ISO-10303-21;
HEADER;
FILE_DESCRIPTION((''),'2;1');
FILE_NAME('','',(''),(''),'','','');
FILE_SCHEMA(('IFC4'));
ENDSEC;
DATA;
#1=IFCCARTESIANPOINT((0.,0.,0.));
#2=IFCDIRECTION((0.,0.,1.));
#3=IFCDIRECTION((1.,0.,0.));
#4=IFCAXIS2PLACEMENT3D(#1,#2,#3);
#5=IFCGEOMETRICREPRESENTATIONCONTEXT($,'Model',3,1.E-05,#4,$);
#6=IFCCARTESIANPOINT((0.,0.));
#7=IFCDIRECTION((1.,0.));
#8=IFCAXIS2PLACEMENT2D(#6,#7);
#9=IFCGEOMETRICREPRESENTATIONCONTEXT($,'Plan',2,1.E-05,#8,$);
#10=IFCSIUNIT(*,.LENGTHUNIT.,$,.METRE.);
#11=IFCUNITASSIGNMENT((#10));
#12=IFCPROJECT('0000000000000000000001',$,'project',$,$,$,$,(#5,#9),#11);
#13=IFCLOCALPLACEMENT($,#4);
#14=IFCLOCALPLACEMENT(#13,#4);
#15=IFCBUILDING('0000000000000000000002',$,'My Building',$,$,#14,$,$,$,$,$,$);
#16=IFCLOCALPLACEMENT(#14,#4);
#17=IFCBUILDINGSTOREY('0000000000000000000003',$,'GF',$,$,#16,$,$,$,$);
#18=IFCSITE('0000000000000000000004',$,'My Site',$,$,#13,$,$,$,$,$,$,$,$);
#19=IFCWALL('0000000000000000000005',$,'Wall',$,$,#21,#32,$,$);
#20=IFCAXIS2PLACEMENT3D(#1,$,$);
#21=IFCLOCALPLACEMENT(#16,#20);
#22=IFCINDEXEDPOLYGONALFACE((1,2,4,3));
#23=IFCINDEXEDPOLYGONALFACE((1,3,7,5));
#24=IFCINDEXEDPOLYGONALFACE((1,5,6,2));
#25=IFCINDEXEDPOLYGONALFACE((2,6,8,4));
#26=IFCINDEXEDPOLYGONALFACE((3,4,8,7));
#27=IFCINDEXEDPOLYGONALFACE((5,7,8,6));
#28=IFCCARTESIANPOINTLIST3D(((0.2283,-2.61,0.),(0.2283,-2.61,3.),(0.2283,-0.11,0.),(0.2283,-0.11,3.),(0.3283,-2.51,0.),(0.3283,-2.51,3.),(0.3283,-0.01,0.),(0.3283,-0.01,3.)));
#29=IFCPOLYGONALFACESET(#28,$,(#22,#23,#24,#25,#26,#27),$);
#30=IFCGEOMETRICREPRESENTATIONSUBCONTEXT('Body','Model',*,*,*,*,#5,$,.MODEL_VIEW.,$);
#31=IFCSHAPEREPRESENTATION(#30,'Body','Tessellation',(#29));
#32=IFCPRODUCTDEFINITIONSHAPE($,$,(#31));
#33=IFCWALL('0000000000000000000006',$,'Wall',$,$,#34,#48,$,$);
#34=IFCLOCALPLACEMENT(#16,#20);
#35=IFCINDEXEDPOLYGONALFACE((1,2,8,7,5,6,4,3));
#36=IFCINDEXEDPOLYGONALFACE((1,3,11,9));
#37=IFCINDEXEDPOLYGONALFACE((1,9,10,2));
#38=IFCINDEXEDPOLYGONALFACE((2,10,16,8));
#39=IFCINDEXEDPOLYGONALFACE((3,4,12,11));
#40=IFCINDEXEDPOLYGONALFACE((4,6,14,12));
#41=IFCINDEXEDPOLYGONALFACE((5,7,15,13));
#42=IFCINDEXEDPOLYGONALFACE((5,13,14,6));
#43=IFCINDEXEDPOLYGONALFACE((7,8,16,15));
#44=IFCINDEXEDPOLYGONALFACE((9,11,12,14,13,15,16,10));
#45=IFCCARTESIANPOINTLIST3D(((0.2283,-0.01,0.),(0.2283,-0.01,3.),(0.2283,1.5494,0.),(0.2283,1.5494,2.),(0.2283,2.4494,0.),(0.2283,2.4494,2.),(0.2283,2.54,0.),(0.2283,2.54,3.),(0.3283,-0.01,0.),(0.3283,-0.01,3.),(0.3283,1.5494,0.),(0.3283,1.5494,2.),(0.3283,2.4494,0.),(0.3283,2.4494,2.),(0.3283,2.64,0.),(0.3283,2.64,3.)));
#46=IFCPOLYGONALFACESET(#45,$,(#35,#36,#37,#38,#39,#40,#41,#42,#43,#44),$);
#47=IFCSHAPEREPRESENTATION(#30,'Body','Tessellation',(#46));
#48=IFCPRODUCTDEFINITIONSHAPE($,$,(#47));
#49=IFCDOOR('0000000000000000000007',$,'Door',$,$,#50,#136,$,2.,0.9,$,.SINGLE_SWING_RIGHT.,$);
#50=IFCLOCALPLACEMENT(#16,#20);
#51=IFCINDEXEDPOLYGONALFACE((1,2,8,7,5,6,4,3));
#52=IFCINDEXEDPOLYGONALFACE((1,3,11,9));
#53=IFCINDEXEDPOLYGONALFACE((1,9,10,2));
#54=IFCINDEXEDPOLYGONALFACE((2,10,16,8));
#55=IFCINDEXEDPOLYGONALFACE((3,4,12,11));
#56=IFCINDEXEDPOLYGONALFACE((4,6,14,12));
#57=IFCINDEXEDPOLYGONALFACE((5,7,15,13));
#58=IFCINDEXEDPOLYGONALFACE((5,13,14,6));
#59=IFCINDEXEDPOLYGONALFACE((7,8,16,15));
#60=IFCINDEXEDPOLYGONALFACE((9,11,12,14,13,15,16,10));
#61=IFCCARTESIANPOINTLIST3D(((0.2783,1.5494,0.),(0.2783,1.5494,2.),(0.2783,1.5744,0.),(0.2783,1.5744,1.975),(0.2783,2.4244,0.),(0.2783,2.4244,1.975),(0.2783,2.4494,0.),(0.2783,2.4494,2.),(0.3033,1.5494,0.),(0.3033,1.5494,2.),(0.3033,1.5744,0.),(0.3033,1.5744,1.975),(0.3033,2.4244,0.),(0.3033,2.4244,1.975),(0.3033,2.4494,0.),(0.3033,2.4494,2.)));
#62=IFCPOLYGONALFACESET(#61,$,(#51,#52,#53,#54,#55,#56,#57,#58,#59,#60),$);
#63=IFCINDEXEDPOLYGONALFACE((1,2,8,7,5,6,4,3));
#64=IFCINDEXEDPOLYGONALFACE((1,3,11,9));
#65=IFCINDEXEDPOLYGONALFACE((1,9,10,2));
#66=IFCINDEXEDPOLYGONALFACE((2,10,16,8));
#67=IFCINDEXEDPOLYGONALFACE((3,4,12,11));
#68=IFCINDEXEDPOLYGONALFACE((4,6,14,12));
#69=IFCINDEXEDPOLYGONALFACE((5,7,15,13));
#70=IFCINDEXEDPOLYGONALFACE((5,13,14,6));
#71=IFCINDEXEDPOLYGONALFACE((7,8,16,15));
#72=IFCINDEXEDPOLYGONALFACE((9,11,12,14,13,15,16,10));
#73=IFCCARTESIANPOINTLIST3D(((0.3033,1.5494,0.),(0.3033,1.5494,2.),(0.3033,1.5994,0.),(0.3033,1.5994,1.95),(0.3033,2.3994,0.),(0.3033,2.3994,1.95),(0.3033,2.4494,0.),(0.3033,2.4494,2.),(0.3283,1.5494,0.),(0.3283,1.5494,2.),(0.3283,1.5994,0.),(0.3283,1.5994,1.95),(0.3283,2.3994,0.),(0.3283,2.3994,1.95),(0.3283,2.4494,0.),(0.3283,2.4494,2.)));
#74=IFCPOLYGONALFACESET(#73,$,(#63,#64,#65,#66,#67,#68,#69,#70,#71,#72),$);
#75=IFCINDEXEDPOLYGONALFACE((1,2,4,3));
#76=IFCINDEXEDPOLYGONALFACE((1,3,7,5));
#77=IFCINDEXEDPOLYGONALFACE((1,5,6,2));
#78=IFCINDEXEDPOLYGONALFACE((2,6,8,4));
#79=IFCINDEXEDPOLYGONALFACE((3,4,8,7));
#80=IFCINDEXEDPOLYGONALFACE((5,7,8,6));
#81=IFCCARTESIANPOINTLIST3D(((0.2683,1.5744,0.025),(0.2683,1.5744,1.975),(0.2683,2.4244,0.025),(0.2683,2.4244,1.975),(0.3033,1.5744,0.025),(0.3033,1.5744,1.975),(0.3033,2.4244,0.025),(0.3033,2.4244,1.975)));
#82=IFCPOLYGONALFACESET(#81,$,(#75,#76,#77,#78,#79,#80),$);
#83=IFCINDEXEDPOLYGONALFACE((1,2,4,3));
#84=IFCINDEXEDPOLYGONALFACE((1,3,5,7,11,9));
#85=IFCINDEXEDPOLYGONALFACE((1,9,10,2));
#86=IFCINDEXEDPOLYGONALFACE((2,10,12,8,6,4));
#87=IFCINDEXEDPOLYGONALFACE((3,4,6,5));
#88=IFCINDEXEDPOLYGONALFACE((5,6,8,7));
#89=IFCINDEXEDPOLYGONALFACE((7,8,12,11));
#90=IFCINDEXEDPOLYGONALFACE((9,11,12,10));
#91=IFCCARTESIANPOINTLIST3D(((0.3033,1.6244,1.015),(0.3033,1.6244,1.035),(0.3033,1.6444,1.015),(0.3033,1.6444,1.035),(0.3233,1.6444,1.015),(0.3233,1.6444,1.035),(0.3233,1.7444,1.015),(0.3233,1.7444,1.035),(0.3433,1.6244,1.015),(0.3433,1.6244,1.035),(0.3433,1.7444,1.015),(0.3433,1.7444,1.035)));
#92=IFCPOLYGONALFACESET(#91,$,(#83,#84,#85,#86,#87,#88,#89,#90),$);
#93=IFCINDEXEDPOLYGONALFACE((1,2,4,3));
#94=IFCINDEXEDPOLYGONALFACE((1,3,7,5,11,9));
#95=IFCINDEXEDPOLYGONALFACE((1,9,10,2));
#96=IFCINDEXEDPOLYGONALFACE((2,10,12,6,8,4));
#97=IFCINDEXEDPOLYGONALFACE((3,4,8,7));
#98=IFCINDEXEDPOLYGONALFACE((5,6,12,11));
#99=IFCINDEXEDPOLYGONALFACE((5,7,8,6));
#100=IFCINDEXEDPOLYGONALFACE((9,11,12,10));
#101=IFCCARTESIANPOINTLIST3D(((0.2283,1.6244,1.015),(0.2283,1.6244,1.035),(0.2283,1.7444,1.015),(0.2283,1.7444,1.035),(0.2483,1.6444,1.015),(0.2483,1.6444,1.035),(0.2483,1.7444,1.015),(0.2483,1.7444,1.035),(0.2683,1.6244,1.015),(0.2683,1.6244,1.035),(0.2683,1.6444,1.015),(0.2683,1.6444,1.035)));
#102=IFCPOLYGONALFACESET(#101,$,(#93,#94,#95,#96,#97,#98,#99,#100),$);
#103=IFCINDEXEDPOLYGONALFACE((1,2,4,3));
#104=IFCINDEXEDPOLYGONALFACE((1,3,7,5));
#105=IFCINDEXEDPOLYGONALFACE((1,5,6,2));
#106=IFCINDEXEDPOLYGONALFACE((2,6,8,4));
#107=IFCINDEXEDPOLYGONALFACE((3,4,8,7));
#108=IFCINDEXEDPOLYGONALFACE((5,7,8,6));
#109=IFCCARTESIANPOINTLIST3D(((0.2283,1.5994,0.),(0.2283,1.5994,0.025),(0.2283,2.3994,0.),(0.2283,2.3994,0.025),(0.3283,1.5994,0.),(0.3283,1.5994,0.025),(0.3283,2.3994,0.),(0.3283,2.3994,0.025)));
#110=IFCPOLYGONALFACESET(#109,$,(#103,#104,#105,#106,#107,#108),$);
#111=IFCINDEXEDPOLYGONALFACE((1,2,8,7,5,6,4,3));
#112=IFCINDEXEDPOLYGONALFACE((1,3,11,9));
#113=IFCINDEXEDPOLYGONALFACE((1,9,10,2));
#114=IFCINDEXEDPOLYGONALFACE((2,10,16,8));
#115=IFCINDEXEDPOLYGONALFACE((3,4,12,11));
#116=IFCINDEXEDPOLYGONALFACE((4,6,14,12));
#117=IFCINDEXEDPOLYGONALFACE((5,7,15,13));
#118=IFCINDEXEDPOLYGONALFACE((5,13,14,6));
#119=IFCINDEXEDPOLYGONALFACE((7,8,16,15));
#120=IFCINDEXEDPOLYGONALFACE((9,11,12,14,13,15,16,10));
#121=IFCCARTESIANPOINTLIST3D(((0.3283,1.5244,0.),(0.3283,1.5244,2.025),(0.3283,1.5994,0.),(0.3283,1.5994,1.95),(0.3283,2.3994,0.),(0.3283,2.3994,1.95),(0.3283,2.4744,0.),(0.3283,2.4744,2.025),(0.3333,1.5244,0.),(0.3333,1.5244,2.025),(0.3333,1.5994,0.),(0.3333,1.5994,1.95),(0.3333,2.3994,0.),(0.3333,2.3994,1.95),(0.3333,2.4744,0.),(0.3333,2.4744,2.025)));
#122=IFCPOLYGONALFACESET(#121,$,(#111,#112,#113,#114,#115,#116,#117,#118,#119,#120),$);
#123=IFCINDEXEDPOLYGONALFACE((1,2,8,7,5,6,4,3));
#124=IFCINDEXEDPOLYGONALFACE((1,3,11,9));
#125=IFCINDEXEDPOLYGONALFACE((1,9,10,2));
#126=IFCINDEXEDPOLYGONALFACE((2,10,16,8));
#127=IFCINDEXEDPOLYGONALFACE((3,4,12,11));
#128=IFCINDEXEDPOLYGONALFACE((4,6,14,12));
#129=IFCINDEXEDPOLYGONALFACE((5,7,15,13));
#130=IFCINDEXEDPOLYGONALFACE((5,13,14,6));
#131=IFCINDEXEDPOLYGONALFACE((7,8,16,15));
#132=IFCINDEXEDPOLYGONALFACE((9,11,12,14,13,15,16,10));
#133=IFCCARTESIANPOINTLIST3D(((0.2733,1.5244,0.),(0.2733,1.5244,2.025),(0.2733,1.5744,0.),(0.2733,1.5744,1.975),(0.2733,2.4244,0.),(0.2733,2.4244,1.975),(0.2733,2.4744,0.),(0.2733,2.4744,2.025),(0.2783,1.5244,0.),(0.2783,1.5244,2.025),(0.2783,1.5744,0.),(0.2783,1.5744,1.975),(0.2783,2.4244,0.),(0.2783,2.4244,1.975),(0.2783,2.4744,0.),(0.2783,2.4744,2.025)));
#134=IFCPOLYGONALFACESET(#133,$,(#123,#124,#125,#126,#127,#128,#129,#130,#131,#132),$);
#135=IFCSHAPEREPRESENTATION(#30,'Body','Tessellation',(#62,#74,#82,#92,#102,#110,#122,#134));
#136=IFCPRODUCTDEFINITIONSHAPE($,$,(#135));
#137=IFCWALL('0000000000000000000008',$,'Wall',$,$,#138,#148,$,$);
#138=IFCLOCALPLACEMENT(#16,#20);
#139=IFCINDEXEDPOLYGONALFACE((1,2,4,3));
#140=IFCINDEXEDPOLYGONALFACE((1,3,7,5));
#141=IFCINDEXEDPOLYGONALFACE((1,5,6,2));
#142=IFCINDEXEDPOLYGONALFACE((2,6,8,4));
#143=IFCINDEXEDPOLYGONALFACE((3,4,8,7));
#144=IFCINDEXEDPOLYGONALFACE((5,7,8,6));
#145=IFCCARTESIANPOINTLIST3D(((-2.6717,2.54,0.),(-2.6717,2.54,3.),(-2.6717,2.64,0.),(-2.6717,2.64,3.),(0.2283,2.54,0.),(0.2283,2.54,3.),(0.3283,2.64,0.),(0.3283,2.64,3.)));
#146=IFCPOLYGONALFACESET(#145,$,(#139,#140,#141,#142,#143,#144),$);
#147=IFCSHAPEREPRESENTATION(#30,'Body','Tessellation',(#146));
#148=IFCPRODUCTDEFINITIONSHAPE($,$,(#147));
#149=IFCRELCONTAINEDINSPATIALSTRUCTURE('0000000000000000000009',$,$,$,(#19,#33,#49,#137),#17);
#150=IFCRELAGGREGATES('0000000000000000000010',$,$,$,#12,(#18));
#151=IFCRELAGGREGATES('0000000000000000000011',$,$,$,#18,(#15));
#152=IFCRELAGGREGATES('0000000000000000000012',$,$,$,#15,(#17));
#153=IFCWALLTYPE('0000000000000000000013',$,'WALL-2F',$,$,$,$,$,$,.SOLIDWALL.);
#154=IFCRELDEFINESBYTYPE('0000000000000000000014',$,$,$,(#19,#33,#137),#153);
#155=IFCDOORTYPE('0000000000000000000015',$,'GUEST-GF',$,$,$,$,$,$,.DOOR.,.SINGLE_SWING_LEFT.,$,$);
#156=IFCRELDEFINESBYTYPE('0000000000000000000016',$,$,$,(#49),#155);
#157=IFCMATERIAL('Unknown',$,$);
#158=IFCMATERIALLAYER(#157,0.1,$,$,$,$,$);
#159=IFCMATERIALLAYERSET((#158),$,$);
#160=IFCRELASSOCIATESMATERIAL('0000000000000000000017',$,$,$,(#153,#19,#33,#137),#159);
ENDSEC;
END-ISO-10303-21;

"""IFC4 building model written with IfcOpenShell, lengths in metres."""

from ifc_helpers import new_model, entity, si_unit, frame, origin_with_axes, origin_2d_with_axis, place, context, subcontext, project, spatial, line, indexed_curve, outline, extrude, shape, source, transform, mapped, material, layer, layer_set, layer_usage, type_object, type_shapes, element, fill, save


model = new_model("IFC4")

# Units and contexts
model_context = context("Model", 3, precision=1e-05, world=origin_with_axes())
plan_context = context("Plan", 2, precision=1e-05, world=origin_2d_with_axis())
body_context_1 = subcontext(model_context, "Body", "Model", "MODEL_VIEW")
body_context_2 = subcontext(plan_context, "Body", "Plan", "PLAN_VIEW")
ifc_project = project(units=[si_unit("LENGTHUNIT", "METRE")], contexts=[model_context, plan_context])

# Site, building, storey
site_placement = place(None, origin_with_axes())
site = spatial("IfcSite", under=ifc_project, at=site_placement, Name="My Site")
building_placement = place(site_placement, origin_with_axes())
building = spatial("IfcBuilding", under=site, at=building_placement, Name="My Building")
storey_placement = place(building_placement, origin_with_axes())
storey = spatial("IfcBuildingStorey", under=building, at=storey_placement, Name="GF")

# Shared definitions
ifc_material = material(Name="Unknown")

# Shared definitions
ifc_layer_1 = layer(ifc_material, 0.1)
ifc_layer_set_1 = layer_set([ifc_layer_1])
wall_type = type_object("IfcWallType", Name="WALL-2F", PredefinedType="SOLIDWALL", material=ifc_layer_set_1)

# Wall
ifc_layer_usage_1 = layer_usage(ifc_layer_set_1, "AXIS2", "POSITIVE", 0.0)
wall_1_placement = place(storey_placement, frame((0.2283, -0.11, 0.0), z_axis=(0.0, 0.0, 1.0), x_axis=(0.0, -1.0, 0.0)))
element("IfcWall", 1, at=wall_1_placement, inside=storey, type_object=wall_type, material=ifc_layer_usage_1, Name="Wall", context=body_context_1, shape_type="SweptSolid", body=[
    extrude(outline(indexed_curve([(0.0, 0.0), (-0.1, 0.1), (2.4, 0.1), (2.5, 0.0)], segments=[line(1, 2, 3, 4, 1)])), origin_with_axes(), (0.0, 0.0, 1.0), 3.0),
])

# Wall, opening, door
ifc_layer_usage_2 = layer_usage(ifc_layer_set_1, "AXIS2", "POSITIVE", 0.0)
wall_2_placement = place(storey_placement, frame((0.3283, -0.01, 0.0), z_axis=(0.0, 0.0, 1.0), x_axis=(0.0, 1.0, 0.0)))
wall_2 = element("IfcWall", 2, at=wall_2_placement, inside=storey, type_object=wall_type, material=ifc_layer_usage_2, Name="Wall", context=body_context_1, shape_type="SweptSolid", body=[
    extrude(outline(indexed_curve([(0.0, 0.0), (0.0, 0.1), (2.55, 0.1), (2.65, 0.0)], segments=[line(1, 2, 3, 4, 1)])), origin_with_axes(), (0.0, 0.0, 1.0), 3.0),
])
shared_shape_1 = source(origin_with_axes(), body_context_1, "Body", "SweptSolid", [
    extrude(outline(indexed_curve([(0.0, 0.0), (0.9, 0.0), (0.9, 2.0), (0.0, 2.0)], segments=[line(1, 2, 3, 4, 1)])), frame((0.0, -0.6, 0.0), z_axis=(0.0, -1.0, 0.0), x_axis=(1.0, 0.0, 0.0)), (0.0, 0.0, -1.0), 1.2),
])
opening_1_placement = place(wall_2_placement, frame((1.5595, 0.0, 0.0), z_axis=(0.0, 0.0, 1.0), x_axis=(1.0, 0.0, 0.0)))
opening_1 = element("IfcOpeningElement", 3, at=opening_1_placement, cuts=wall_2, PredefinedType="OPENING", context=body_context_1, shape_type="MappedRepresentation", body=[
    mapped(shared_shape_1, transform((0.0, 0.0, 0.0), x_axis=(1.0, 0.0, 0.0), y_axis=(0.0, 1.0, 0.0), z_axis=(0.0, 0.0, 1.0), scale=1.0)),
])
door_type_1 = type_object("IfcDoorType", Name="GUEST-GF", OperationType="SINGLE_SWING_LEFT", PredefinedType="DOOR")
shared_shape_2 = source(origin_with_axes(), body_context_1, "Body", "SweptSolid", [
    extrude(outline(indexed_curve([(0.0, 0.0), (0.0, 2.0), (0.9, 2.0), (0.9, 0.0), (0.875, 0.0), (0.875, 1.975), (0.025, 1.975), (0.025, 0.0)], segments=[line(1, 2, 3, 4, 5, 6, 7, 8, 1)])), frame((0.0, 0.025, 0.0), z_axis=(0.0, -1.0, 0.0), x_axis=(1.0, 0.0, 0.0)), (0.0, 0.0, -1.0), 0.025),
    extrude(outline(indexed_curve([(0.0, 0.0), (0.0, 2.0), (0.9, 2.0), (0.9, 0.0), (0.85, 0.0), (0.85, 1.95), (0.05, 1.95), (0.05, 0.0)], segments=[line(1, 2, 3, 4, 5, 6, 7, 8, 1)])), frame((0.0, 0.0, 0.0), z_axis=(0.0, -1.0, 0.0), x_axis=(1.0, 0.0, 0.0)), (0.0, 0.0, -1.0), 0.025),
    extrude(outline(indexed_curve([(0.0, 0.0), (0.85, 0.0), (0.85, 0.035), (0.0, 0.035)], segments=[line(1, 2, 3, 4, 1)])), frame((0.025, 0.025, 0.025), z_axis=(0.0, 0.0, 1.0), x_axis=(1.0, 0.0, 0.0)), (0.0, 0.0, 1.0), 1.95),
    extrude(outline(indexed_curve([(0.0, 0.0), (0.0, -0.04), (0.12, -0.04), (0.12, -0.02), (0.02, -0.02), (0.02, 0.0)], segments=[line(1, 2, 3, 4, 5, 6, 1)])), frame((0.075, 0.025, 1.015), z_axis=(0.0, 0.0, 1.0), x_axis=(1.0, 0.0, 0.0)), (0.0, 0.0, 1.0), 0.02),
    extrude(outline(indexed_curve([(0.0, 0.0), (0.0, 0.04), (0.12, 0.04), (0.12, 0.02), (0.02, 0.02), (0.02, 0.0)], segments=[line(1, 2, 3, 4, 5, 6, 1)])), frame((0.075, 0.06, 1.015), z_axis=(0.0, 0.0, 1.0), x_axis=(1.0, 0.0, 0.0)), (0.0, 0.0, 1.0), 0.02),
    extrude(outline(indexed_curve([(0.0, 0.0), (0.8, 0.0), (0.8, 0.1), (0.0, 0.1)], segments=[line(1, 2, 3, 4, 1)])), frame((0.05, 0.0, 0.0), z_axis=(0.0, 0.0, 1.0), x_axis=(1.0, 0.0, 0.0)), (0.0, 0.0, 1.0), 0.025),
    extrude(outline(indexed_curve([(0.0, 0.0), (0.0, 2.025), (0.95, 2.025), (0.95, 0.0), (0.875, 0.0), (0.875, 1.95), (0.075, 1.95), (0.075, 0.0)], segments=[line(1, 2, 3, 4, 5, 6, 7, 8, 1)])), frame((-0.025, -0.005, 0.0), z_axis=(0.0, -1.0, 0.0), x_axis=(1.0, 0.0, 0.0)), (0.0, 0.0, -1.0), 0.005),
    extrude(outline(indexed_curve([(0.0, 0.0), (0.0, 2.025), (0.95, 2.025), (0.95, 0.0), (0.9, 0.0), (0.9, 1.975), (0.05, 1.975), (0.05, 0.0)], segments=[line(1, 2, 3, 4, 5, 6, 7, 8, 1)])), frame((-0.025, 0.05, 0.0), z_axis=(0.0, -1.0, 0.0), x_axis=(1.0, 0.0, 0.0)), (0.0, 0.0, -1.0), 0.005),
])
shared_shape_3 = source(origin_with_axes(), body_context_2, "Body", "Curve2D", [
    entity("IfcIndexedPolyCurve", entity("IfcCartesianPointList2D", [[0.0, 0.0], [0.0, 0.05], [0.025, 0.05], [0.025, 0.025], [0.05, 0.025], [0.05, 0.0]]), [entity("IfcLineIndex", [1, 2, 3, 4, 5, 6, 1])]),
    entity("IfcIndexedPolyCurve", entity("IfcCartesianPointList2D", [[0.9, 0.0], [0.9, 0.05], [0.875, 0.05], [0.875, 0.025], [0.85, 0.025], [0.85, 0.0]]), [entity("IfcLineIndex", [1, 2, 3, 4, 5, 6, 1])]),
    entity("IfcTrimmedCurve", entity("IfcEllipse", entity("IfcAxis2Placement2D", entity("IfcCartesianPoint", [0.84, 0.05]), entity("IfcDirection", [1.0, 0.0])), 0.815, 0.85), [entity("IfcCartesianPoint", [0.84, 0.9])], [entity("IfcCartesianPoint", [0.025, 0.05])], True, "CARTESIAN"),
    entity("IfcIndexedPolyCurve", entity("IfcCartesianPointList2D", [[0.875, 0.05], [0.84, 0.05], [0.84, 0.9], [0.875, 0.9]]), [entity("IfcLineIndex", [1, 2, 3, 4, 1])]),
])
type_shapes(door_type_1, [shared_shape_2, shared_shape_3])
door_1_placement = place(opening_1_placement, frame((0.0, 0.0, 0.0), z_axis=(0.0, 0.0, 1.0), x_axis=(1.0, 0.0, 0.0)))
door_1 = element("IfcDoor", 4, at=door_1_placement, inside=storey, type_object=door_type_1, Name="Door", OperationType="SINGLE_SWING_RIGHT", OverallHeight=2.0, OverallWidth=0.9, shapes=[
    shape(body_context_1, "Body", "MappedRepresentation", [mapped(shared_shape_2, transform((0.0, 0.0, 0.0), x_axis=(1.0, 0.0, 0.0), y_axis=(0.0, 1.0, 0.0), z_axis=(0.0, 0.0, 1.0), scale=1.0))]),
    shape(body_context_2, "Body", "MappedRepresentation", [mapped(shared_shape_3, transform((0.0, 0.0, 0.0), x_axis=(1.0, 0.0, 0.0), y_axis=(0.0, 1.0, 0.0), z_axis=(0.0, 0.0, 1.0), scale=1.0))]),
])
fill(opening_1, door_1)

# Wall
ifc_layer_usage_3 = layer_usage(ifc_layer_set_1, "AXIS2", "POSITIVE", 0.0)
wall_3_placement = place(storey_placement, frame((0.3283, 2.64, 0.0), z_axis=(0.0, 0.0, 1.0), x_axis=(-1.0, 0.0, 0.0)))
element("IfcWall", 5, at=wall_3_placement, inside=storey, type_object=wall_type, material=ifc_layer_usage_3, Name="Wall", context=body_context_1, shape_type="SweptSolid", body=[
    extrude(outline(indexed_curve([(0.0, 0.0), (0.1, 0.1), (3.0, 0.1), (3.0, 0.0)], segments=[line(1, 2, 3, 4, 1)])), origin_with_axes(), (0.0, 0.0, 1.0), 3.0),
])

save(model, "model.ifc")
